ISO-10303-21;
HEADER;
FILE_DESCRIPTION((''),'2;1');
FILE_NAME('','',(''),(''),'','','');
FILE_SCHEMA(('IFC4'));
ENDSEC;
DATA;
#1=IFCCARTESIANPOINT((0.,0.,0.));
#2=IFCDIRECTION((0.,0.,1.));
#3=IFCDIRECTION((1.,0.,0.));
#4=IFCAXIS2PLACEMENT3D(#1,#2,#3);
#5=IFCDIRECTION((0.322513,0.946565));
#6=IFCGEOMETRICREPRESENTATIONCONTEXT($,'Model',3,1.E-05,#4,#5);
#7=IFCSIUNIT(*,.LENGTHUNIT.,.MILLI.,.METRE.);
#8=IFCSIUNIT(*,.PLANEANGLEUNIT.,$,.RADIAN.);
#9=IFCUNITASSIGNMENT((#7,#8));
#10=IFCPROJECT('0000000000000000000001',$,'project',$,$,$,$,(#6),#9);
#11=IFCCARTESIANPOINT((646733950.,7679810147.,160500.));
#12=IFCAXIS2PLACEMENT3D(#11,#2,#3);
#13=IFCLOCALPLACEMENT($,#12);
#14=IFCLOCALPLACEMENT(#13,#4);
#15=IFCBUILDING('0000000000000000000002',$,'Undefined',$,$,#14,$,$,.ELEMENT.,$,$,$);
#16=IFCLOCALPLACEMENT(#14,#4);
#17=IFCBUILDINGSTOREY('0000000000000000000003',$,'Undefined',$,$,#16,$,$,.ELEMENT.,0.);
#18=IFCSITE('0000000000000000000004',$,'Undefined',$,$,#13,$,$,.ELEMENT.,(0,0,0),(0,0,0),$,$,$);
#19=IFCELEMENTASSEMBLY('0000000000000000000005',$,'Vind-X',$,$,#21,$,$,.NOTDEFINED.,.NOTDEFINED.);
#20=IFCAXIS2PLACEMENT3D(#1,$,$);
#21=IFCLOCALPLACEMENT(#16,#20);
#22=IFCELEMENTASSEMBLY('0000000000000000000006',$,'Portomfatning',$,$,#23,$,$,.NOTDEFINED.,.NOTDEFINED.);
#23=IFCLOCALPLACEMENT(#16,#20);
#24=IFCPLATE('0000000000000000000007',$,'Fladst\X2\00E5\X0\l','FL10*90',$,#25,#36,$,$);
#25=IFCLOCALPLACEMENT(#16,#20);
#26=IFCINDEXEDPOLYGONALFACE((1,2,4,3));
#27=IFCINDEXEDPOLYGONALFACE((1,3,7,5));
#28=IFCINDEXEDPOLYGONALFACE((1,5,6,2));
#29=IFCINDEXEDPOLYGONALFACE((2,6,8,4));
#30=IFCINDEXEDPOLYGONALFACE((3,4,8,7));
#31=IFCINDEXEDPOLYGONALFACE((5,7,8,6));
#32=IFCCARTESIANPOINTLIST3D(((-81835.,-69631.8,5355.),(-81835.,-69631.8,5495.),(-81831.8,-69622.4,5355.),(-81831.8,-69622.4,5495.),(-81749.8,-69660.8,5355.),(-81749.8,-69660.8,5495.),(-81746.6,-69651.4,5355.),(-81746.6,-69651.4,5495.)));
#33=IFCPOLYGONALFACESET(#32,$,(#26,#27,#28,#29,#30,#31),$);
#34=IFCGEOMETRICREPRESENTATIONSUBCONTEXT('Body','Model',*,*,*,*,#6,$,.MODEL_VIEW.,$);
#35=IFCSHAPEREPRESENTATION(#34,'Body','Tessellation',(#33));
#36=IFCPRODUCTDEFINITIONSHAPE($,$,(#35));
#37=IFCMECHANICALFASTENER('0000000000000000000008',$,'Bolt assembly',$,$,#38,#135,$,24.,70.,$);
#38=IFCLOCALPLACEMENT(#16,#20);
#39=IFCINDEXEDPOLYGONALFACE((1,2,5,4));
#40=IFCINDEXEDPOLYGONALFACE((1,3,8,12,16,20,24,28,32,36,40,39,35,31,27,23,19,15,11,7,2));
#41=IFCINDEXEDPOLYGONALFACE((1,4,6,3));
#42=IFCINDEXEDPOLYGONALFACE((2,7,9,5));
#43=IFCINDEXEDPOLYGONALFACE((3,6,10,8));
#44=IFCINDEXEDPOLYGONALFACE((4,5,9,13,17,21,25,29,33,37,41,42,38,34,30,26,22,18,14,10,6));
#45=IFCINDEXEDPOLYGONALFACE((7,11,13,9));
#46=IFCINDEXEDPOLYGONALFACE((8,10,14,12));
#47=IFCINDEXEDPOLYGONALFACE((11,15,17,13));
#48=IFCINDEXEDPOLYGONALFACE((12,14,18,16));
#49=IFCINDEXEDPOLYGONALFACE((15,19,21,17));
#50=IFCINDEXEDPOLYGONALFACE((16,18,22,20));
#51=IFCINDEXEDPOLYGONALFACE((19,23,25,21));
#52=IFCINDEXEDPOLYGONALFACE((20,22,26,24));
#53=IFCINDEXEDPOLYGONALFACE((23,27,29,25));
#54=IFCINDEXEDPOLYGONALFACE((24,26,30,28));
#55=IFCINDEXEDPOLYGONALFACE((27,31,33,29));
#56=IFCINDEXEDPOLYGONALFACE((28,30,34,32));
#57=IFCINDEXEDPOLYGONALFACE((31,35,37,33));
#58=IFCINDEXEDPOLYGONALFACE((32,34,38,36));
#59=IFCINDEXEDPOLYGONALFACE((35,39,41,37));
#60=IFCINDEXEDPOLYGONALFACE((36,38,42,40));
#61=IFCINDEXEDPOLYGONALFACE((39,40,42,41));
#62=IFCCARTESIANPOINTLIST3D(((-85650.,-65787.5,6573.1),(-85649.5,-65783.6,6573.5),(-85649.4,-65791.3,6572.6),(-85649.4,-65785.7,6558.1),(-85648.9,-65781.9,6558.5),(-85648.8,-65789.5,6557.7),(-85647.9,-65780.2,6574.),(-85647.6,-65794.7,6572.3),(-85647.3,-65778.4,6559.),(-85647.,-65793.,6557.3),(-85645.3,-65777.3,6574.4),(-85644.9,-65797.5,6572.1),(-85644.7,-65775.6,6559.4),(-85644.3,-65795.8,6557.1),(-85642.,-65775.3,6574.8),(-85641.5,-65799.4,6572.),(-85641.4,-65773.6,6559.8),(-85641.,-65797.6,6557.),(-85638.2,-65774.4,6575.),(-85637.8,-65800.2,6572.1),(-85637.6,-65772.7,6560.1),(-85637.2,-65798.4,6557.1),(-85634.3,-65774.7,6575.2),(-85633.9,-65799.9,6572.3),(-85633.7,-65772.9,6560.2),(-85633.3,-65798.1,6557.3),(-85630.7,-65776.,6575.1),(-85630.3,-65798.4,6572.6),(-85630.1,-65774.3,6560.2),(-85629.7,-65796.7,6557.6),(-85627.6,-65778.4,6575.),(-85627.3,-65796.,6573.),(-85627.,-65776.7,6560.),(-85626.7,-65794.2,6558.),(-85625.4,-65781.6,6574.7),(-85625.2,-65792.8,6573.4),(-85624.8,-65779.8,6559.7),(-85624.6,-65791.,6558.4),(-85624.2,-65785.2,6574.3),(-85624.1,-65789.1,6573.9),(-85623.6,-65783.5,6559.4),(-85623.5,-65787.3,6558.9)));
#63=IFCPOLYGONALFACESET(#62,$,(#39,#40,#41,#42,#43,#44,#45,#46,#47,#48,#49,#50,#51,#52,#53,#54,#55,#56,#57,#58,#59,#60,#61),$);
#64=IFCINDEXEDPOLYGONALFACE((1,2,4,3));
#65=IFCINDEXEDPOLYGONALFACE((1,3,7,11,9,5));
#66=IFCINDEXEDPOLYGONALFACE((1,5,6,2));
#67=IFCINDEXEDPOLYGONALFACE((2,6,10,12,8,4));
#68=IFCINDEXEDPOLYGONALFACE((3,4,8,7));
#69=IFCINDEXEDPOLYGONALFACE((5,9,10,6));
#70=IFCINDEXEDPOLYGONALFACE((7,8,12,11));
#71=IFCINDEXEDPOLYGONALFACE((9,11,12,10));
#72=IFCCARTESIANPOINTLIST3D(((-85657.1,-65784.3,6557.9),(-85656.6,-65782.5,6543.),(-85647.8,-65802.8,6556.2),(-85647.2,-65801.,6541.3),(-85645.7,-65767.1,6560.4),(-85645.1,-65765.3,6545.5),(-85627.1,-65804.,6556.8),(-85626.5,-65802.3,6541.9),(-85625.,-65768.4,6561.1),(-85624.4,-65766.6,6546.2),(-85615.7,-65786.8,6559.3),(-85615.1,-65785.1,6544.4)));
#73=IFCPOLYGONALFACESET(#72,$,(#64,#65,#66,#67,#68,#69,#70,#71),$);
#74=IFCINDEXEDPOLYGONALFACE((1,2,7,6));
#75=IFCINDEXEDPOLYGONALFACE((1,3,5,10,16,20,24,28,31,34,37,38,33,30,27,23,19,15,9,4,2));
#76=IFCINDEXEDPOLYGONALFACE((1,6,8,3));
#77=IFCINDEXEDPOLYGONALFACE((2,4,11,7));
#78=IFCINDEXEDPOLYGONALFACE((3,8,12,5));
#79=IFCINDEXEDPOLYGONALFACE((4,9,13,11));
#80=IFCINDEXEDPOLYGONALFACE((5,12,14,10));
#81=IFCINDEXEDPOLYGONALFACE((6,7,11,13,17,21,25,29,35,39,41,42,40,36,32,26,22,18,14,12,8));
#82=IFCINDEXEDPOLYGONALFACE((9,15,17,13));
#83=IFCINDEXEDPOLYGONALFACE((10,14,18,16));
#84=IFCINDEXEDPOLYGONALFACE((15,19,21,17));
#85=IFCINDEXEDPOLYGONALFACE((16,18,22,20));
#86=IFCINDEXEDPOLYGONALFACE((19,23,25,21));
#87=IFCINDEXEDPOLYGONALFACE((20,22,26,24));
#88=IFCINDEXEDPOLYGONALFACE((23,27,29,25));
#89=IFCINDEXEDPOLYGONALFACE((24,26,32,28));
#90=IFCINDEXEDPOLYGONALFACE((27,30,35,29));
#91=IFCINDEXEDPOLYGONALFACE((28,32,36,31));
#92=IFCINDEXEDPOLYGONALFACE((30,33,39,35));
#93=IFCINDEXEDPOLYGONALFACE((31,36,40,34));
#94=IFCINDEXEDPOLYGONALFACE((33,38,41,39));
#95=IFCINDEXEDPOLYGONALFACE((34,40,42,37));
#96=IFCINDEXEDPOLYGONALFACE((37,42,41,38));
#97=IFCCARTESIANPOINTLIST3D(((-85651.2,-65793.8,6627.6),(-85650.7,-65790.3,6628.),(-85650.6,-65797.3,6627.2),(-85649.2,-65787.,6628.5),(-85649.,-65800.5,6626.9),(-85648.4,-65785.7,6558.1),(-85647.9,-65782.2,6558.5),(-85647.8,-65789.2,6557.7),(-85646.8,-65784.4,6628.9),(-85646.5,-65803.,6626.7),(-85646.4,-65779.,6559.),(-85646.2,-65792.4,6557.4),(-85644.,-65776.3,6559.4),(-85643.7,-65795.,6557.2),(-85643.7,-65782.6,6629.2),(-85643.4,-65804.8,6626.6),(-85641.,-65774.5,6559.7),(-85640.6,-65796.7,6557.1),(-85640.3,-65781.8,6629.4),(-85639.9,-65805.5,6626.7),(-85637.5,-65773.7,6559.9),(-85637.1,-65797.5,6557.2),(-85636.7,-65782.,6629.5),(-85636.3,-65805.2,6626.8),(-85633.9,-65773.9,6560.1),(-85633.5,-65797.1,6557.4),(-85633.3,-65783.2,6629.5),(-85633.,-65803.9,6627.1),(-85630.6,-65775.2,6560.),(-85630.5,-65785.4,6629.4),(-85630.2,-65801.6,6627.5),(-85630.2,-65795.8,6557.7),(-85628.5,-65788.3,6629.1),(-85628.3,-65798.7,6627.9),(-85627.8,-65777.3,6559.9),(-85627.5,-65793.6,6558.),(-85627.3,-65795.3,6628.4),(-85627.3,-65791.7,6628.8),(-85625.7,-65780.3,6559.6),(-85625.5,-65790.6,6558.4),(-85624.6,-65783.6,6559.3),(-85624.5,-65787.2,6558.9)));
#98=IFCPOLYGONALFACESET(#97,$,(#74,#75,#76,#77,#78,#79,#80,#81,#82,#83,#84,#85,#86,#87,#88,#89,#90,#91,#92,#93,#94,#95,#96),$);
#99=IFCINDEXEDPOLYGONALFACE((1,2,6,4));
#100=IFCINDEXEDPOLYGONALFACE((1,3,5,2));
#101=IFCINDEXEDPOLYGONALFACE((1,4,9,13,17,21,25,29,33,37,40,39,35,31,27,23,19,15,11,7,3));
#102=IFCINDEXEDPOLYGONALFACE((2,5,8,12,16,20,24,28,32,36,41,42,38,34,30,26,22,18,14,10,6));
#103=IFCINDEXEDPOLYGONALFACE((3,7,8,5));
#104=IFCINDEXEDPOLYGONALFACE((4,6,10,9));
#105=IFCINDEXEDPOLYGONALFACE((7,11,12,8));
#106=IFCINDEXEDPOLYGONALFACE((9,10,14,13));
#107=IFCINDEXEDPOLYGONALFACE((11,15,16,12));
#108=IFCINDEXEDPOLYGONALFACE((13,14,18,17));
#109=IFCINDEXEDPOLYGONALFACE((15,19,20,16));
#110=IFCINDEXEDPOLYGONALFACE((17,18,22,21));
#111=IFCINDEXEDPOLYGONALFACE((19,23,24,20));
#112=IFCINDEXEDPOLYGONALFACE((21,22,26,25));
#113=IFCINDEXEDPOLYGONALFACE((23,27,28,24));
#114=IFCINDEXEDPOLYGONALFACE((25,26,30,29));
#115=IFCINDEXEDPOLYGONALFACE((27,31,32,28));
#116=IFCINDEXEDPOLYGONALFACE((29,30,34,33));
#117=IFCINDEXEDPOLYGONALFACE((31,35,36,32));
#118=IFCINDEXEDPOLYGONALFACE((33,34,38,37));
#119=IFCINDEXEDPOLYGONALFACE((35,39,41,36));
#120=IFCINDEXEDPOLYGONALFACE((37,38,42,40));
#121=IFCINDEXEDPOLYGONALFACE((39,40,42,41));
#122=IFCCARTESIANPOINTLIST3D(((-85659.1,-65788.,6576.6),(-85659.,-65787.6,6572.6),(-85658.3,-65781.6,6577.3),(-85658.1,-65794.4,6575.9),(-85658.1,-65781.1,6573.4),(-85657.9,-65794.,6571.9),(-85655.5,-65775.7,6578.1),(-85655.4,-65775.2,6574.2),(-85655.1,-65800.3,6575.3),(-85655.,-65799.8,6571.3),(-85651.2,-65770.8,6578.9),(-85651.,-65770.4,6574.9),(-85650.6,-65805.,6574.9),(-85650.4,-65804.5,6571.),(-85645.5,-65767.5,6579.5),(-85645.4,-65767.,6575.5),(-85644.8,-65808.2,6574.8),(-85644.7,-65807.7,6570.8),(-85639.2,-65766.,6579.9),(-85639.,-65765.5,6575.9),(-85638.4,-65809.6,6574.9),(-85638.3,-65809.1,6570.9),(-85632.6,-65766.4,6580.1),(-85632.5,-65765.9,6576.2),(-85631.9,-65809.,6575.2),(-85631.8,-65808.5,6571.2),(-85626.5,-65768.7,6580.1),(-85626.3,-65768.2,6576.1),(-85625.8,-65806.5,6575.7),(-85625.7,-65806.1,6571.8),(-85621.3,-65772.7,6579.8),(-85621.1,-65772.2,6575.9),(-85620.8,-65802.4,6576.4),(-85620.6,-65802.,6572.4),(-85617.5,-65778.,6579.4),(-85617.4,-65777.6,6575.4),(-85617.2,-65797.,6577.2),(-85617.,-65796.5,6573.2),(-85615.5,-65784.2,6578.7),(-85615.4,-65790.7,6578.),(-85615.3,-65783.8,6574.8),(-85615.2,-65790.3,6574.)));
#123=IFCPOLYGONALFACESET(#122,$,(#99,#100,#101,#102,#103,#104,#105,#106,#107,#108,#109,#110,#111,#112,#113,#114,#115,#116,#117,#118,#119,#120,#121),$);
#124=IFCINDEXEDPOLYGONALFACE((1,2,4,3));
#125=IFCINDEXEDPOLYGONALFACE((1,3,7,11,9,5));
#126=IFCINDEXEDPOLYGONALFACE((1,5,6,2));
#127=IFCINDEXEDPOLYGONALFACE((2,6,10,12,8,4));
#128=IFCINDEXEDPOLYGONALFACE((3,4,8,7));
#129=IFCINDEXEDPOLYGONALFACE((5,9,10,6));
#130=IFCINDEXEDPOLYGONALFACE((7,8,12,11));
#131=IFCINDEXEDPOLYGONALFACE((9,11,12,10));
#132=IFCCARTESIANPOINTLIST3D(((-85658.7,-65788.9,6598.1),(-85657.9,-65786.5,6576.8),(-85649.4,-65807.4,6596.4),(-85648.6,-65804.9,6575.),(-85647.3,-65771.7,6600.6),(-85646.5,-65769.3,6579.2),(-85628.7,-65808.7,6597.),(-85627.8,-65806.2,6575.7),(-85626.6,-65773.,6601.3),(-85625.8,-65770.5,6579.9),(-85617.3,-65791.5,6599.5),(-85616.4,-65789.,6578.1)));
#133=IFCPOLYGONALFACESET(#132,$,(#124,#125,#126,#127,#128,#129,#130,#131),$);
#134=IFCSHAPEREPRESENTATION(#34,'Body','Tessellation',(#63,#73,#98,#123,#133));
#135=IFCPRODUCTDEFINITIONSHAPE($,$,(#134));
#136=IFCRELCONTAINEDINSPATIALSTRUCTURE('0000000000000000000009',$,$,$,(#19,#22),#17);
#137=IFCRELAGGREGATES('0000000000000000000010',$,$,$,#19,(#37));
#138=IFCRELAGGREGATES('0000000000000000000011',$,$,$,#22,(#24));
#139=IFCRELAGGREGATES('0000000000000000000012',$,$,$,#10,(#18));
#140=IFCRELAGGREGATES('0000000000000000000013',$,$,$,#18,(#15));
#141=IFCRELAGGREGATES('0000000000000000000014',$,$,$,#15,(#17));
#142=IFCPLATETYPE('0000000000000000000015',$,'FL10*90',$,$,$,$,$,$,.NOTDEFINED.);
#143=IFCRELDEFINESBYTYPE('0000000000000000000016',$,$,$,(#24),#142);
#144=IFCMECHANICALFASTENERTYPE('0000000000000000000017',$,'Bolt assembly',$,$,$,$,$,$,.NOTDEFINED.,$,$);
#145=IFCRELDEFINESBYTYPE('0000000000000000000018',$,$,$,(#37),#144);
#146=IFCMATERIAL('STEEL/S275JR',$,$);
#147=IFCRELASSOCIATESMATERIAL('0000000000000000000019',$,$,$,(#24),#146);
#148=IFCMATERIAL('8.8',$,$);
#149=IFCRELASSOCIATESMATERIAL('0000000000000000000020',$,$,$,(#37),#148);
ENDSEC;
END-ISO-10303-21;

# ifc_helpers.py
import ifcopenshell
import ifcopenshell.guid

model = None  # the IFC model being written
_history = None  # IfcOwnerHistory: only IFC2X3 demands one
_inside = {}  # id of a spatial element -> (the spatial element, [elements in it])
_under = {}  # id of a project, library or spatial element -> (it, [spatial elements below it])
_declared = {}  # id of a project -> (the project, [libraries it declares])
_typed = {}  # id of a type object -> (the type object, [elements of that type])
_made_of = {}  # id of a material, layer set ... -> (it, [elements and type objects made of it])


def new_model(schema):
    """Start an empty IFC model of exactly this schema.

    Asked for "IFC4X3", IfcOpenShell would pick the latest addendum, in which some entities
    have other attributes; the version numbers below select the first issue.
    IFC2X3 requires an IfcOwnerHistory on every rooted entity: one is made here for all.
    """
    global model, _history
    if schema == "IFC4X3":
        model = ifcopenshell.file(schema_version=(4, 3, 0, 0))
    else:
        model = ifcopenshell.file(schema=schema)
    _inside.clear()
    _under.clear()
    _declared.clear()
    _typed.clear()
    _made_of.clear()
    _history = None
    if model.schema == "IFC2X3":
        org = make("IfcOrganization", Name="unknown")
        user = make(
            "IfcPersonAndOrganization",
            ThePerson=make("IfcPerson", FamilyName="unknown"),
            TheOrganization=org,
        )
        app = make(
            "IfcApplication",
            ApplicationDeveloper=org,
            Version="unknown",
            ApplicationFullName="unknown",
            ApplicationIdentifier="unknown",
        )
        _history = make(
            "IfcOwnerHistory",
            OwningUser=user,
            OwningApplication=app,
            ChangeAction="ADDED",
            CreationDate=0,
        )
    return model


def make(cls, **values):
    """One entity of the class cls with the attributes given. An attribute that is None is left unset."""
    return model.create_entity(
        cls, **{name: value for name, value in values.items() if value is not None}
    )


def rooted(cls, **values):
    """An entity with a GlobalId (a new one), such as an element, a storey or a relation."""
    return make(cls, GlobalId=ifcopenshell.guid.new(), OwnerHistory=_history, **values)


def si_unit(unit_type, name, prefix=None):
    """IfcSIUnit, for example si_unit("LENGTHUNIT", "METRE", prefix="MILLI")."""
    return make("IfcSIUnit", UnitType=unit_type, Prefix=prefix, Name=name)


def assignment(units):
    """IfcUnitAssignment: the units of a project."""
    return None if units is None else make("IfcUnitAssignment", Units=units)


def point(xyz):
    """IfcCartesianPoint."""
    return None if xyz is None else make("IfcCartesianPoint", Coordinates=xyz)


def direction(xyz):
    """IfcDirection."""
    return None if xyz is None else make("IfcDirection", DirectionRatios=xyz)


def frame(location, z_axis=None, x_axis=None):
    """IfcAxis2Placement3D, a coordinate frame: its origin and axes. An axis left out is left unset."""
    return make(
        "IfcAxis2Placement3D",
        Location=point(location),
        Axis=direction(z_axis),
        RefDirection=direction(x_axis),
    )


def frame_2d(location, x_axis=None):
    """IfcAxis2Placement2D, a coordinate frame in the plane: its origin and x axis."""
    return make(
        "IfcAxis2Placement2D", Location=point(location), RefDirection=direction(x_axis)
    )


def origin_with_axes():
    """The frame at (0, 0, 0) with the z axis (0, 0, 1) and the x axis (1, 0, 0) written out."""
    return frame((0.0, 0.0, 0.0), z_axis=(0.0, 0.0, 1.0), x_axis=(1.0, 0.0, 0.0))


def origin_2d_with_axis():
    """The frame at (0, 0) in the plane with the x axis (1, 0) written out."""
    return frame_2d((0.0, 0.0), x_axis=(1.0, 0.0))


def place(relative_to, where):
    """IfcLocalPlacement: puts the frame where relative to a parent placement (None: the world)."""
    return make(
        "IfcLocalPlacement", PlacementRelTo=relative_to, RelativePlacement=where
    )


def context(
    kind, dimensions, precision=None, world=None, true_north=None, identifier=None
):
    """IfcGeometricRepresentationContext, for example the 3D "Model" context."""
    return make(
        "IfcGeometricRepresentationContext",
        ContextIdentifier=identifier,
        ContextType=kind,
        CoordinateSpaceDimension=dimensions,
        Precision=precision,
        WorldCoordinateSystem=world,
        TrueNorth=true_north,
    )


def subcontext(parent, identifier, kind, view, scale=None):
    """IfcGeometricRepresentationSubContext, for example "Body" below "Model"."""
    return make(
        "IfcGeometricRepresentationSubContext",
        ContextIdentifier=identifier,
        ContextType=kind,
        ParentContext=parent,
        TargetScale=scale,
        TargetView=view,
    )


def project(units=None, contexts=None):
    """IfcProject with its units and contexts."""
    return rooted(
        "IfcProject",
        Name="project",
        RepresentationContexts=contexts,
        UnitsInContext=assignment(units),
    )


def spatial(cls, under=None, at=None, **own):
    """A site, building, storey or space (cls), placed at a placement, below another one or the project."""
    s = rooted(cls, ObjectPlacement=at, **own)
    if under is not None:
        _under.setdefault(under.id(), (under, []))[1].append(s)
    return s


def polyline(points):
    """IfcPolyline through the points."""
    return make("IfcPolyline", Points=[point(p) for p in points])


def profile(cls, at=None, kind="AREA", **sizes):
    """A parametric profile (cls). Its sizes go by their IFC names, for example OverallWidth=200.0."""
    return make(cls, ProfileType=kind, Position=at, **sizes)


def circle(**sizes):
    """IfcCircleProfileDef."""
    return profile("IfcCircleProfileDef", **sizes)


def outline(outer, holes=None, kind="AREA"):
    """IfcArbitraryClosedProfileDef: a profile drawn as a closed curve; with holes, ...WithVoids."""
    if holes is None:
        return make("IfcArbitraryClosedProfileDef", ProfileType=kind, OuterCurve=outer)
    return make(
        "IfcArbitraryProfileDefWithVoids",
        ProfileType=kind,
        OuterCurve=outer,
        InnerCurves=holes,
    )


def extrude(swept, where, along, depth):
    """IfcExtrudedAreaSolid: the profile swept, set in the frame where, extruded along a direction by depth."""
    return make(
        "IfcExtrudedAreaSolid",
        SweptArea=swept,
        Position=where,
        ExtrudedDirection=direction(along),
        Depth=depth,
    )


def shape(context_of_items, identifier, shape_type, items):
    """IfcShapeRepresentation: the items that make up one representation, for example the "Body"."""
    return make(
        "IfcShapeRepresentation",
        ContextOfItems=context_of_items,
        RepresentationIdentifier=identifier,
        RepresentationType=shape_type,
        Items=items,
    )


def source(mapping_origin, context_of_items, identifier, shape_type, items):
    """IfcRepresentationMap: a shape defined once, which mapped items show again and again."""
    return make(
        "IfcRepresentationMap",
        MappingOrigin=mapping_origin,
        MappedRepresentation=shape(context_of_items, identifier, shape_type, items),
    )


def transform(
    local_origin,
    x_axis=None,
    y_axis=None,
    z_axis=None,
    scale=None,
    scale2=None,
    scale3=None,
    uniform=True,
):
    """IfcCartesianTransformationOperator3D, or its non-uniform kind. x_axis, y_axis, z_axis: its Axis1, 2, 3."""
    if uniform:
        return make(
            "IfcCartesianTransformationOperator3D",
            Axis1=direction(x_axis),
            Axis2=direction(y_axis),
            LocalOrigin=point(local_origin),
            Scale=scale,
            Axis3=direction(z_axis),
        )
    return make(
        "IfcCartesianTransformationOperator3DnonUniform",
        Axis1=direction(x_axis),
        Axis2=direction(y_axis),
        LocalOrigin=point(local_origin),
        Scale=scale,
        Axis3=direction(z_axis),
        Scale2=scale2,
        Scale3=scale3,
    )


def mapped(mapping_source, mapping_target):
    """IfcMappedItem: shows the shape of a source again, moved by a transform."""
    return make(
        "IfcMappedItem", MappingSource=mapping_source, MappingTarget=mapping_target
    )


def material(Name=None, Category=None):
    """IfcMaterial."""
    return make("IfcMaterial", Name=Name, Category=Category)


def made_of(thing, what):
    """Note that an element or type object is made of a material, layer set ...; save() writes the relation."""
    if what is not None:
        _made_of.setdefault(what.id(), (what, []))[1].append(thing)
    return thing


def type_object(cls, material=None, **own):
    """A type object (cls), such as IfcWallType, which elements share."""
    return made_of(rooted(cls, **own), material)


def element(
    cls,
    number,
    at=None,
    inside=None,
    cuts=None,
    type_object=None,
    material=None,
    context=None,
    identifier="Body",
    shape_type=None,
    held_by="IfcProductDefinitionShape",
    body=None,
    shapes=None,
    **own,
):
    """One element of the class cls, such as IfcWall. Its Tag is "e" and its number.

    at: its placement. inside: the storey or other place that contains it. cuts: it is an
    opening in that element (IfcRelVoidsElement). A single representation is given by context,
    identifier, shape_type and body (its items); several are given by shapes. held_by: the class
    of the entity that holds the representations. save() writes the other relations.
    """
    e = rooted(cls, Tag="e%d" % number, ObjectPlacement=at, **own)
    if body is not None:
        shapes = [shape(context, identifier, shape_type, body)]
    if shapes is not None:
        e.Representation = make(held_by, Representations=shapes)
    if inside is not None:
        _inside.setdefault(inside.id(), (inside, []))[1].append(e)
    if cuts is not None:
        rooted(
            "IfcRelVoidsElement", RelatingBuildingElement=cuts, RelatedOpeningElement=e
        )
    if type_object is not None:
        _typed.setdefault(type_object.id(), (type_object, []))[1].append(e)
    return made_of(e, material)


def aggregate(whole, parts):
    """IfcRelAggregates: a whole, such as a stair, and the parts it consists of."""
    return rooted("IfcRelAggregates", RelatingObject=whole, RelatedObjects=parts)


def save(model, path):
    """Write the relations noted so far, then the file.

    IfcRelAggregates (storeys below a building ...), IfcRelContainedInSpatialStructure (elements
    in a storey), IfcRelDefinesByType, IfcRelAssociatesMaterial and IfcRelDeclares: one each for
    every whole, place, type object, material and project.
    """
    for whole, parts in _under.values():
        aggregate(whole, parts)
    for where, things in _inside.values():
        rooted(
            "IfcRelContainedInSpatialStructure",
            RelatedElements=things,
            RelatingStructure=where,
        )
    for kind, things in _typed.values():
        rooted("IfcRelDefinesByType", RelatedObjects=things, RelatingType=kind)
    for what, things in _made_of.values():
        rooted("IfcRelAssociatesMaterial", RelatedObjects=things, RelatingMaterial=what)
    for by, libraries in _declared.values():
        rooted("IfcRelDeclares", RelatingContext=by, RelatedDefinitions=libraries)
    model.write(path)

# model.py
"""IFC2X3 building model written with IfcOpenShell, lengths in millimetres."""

from ifc_helpers import new_model, si_unit, direction, frame, origin_with_axes, origin_2d_with_axis, place, context, subcontext, project, spatial, polyline, circle, outline, extrude, source, transform, mapped, material, type_object, element, aggregate, save


model = new_model("IFC2X3")

# Units and contexts
model_context = context("Model", 3, precision=1e-05, world=origin_with_axes(), true_north=direction((0.322513, 0.946565)))
body_context = subcontext(model_context, "Body", "Model", "MODEL_VIEW")
ifc_project = project(units=[si_unit("LENGTHUNIT", "METRE", prefix="MILLI"), si_unit("PLANEANGLEUNIT", "RADIAN")], contexts=[model_context])

# Site, building, storey
site_placement = place(None, frame((646733950.0, 7679810147.0, 160500.0), z_axis=(0.0, 0.0, 1.0), x_axis=(1.0, 0.0, 0.0)))
site = spatial("IfcSite", under=ifc_project, at=site_placement, Name="Undefined", CompositionType="ELEMENT", RefLatitude=(0, 0, 0), RefLongitude=(0, 0, 0))
building_placement = place(site_placement, origin_with_axes())
building = spatial("IfcBuilding", under=site, at=building_placement, Name="Undefined", CompositionType="ELEMENT")
storey_placement = place(building_placement, origin_with_axes())
storey = spatial("IfcBuildingStorey", under=building, at=storey_placement, Name="Undefined", CompositionType="ELEMENT", Elevation=0.0)

# Shared definitions
ifc_material_1 = material(Name="STEEL/S275JR")

# Element assembly
assembly_1_placement = place(storey_placement, origin_with_axes())
assembly_1 = element("IfcElementAssembly", 1, at=assembly_1_placement, inside=storey, Name="Vind-X", AssemblyPlace="NOTDEFINED", PredefinedType="NOTDEFINED")

# Element assembly, plate
assembly_2_placement = place(storey_placement, origin_with_axes())
assembly_2 = element("IfcElementAssembly", 2, at=assembly_2_placement, inside=storey, Name="Portomfatning", AssemblyPlace="NOTDEFINED", PredefinedType="NOTDEFINED")
plate_type_1 = type_object("IfcPlateType", Name="FL10*90", PredefinedType="NOTDEFINED")
plate_1_placement = place(assembly_2_placement, frame((-81790.8, -69641.6, 5355.0), z_axis=(0.322513, 0.946565, 0.0), x_axis=(0.0, 0.0, 1.0)))
plate_1 = element("IfcPlate", 3, at=plate_1_placement, type_object=plate_type_1, material=ifc_material_1, Name="Fladstål", Description="FL10*90", context=body_context, shape_type="SweptSolid", body=[
    extrude(outline(polyline([(0.0, -45.0), (0.0, 45.0), (140.0, 45.0), (140.0, -45.0), (0.0, -45.0)])), frame((0.0, 0.0, -5.0), z_axis=(0.0, 0.0, 1.0), x_axis=(1.0, 0.0, 0.0)), (0.0, 0.0, 1.0), 10.0),
])

# Mechanical fastener
ifc_material_2 = material(Name="8.8")
mechanical_fastener_type = type_object("IfcMechanicalFastenerType", Name="Bolt assembly")
shared_shape_1 = source(origin_with_axes(), body_context, "Body", "SweptSolid", [
    extrude(circle(Radius=13.0, at=origin_2d_with_axis()), frame((0.0, 0.0, 0.0), z_axis=(0.0, 1.0, 0.0), x_axis=(1.0, 0.0, 0.0)), (0.0, 0.0, 1.0), 15.1),
    extrude(outline(polyline([(18.0, -10.4), (18.0, 10.4), (0.0, 20.8), (-18.0, 10.4), (-18.0, -10.4), (0.0, -20.8), (18.0, -10.4)])), frame((0.0, -15.0, 0.0), z_axis=(0.0, 1.0, 0.0), x_axis=(1.0, 0.0, 0.0)), (0.0, 0.0, 1.0), 15.0),
    extrude(circle(Radius=12.0, at=origin_2d_with_axis()), frame((0.0, 0.0, 0.0), z_axis=(0.0, 1.0, 0.0), x_axis=(1.0, 0.0, 0.0)), (0.0, 0.0, 1.0), 70.0),
    extrude(circle(Radius=22.0, at=origin_2d_with_axis()), frame((0.0, 15.0, 0.0), z_axis=(0.0, 1.0, 0.0), x_axis=(1.0, 0.0, 0.0)), (0.0, 0.0, 1.0), 4.0),
    extrude(outline(polyline([(18.0, -10.4), (18.0, 10.4), (0.0, 20.8), (-18.0, 10.4), (-18.0, -10.4), (0.0, -20.8), (18.0, -10.4)])), frame((0.0, 19.0, 0.0), z_axis=(0.0, 1.0, 0.0), x_axis=(1.0, 0.0, 0.0)), (0.0, 0.0, 1.0), 21.5),
])
mechanical_fastener_1_placement = place(assembly_1_placement, frame((-85636.4, -65785.6, 6558.6), z_axis=(0.448662, -0.88959, -0.085625), x_axis=(0.892837, 0.441952, 0.086721)))
mechanical_fastener_1 = element("IfcMechanicalFastener", 4, at=mechanical_fastener_1_placement, type_object=mechanical_fastener_type, material=ifc_material_2, Name="Bolt assembly", NominalDiameter=24.0, NominalLength=70.0, context=body_context, shape_type="MappedRepresentation", body=[
    mapped(shared_shape_1, transform((0.0, 0.0, 0.0))),
])
aggregate(assembly_1, [mechanical_fastener_1])
aggregate(assembly_2, [plate_1])

save(model, "model.ifc")
